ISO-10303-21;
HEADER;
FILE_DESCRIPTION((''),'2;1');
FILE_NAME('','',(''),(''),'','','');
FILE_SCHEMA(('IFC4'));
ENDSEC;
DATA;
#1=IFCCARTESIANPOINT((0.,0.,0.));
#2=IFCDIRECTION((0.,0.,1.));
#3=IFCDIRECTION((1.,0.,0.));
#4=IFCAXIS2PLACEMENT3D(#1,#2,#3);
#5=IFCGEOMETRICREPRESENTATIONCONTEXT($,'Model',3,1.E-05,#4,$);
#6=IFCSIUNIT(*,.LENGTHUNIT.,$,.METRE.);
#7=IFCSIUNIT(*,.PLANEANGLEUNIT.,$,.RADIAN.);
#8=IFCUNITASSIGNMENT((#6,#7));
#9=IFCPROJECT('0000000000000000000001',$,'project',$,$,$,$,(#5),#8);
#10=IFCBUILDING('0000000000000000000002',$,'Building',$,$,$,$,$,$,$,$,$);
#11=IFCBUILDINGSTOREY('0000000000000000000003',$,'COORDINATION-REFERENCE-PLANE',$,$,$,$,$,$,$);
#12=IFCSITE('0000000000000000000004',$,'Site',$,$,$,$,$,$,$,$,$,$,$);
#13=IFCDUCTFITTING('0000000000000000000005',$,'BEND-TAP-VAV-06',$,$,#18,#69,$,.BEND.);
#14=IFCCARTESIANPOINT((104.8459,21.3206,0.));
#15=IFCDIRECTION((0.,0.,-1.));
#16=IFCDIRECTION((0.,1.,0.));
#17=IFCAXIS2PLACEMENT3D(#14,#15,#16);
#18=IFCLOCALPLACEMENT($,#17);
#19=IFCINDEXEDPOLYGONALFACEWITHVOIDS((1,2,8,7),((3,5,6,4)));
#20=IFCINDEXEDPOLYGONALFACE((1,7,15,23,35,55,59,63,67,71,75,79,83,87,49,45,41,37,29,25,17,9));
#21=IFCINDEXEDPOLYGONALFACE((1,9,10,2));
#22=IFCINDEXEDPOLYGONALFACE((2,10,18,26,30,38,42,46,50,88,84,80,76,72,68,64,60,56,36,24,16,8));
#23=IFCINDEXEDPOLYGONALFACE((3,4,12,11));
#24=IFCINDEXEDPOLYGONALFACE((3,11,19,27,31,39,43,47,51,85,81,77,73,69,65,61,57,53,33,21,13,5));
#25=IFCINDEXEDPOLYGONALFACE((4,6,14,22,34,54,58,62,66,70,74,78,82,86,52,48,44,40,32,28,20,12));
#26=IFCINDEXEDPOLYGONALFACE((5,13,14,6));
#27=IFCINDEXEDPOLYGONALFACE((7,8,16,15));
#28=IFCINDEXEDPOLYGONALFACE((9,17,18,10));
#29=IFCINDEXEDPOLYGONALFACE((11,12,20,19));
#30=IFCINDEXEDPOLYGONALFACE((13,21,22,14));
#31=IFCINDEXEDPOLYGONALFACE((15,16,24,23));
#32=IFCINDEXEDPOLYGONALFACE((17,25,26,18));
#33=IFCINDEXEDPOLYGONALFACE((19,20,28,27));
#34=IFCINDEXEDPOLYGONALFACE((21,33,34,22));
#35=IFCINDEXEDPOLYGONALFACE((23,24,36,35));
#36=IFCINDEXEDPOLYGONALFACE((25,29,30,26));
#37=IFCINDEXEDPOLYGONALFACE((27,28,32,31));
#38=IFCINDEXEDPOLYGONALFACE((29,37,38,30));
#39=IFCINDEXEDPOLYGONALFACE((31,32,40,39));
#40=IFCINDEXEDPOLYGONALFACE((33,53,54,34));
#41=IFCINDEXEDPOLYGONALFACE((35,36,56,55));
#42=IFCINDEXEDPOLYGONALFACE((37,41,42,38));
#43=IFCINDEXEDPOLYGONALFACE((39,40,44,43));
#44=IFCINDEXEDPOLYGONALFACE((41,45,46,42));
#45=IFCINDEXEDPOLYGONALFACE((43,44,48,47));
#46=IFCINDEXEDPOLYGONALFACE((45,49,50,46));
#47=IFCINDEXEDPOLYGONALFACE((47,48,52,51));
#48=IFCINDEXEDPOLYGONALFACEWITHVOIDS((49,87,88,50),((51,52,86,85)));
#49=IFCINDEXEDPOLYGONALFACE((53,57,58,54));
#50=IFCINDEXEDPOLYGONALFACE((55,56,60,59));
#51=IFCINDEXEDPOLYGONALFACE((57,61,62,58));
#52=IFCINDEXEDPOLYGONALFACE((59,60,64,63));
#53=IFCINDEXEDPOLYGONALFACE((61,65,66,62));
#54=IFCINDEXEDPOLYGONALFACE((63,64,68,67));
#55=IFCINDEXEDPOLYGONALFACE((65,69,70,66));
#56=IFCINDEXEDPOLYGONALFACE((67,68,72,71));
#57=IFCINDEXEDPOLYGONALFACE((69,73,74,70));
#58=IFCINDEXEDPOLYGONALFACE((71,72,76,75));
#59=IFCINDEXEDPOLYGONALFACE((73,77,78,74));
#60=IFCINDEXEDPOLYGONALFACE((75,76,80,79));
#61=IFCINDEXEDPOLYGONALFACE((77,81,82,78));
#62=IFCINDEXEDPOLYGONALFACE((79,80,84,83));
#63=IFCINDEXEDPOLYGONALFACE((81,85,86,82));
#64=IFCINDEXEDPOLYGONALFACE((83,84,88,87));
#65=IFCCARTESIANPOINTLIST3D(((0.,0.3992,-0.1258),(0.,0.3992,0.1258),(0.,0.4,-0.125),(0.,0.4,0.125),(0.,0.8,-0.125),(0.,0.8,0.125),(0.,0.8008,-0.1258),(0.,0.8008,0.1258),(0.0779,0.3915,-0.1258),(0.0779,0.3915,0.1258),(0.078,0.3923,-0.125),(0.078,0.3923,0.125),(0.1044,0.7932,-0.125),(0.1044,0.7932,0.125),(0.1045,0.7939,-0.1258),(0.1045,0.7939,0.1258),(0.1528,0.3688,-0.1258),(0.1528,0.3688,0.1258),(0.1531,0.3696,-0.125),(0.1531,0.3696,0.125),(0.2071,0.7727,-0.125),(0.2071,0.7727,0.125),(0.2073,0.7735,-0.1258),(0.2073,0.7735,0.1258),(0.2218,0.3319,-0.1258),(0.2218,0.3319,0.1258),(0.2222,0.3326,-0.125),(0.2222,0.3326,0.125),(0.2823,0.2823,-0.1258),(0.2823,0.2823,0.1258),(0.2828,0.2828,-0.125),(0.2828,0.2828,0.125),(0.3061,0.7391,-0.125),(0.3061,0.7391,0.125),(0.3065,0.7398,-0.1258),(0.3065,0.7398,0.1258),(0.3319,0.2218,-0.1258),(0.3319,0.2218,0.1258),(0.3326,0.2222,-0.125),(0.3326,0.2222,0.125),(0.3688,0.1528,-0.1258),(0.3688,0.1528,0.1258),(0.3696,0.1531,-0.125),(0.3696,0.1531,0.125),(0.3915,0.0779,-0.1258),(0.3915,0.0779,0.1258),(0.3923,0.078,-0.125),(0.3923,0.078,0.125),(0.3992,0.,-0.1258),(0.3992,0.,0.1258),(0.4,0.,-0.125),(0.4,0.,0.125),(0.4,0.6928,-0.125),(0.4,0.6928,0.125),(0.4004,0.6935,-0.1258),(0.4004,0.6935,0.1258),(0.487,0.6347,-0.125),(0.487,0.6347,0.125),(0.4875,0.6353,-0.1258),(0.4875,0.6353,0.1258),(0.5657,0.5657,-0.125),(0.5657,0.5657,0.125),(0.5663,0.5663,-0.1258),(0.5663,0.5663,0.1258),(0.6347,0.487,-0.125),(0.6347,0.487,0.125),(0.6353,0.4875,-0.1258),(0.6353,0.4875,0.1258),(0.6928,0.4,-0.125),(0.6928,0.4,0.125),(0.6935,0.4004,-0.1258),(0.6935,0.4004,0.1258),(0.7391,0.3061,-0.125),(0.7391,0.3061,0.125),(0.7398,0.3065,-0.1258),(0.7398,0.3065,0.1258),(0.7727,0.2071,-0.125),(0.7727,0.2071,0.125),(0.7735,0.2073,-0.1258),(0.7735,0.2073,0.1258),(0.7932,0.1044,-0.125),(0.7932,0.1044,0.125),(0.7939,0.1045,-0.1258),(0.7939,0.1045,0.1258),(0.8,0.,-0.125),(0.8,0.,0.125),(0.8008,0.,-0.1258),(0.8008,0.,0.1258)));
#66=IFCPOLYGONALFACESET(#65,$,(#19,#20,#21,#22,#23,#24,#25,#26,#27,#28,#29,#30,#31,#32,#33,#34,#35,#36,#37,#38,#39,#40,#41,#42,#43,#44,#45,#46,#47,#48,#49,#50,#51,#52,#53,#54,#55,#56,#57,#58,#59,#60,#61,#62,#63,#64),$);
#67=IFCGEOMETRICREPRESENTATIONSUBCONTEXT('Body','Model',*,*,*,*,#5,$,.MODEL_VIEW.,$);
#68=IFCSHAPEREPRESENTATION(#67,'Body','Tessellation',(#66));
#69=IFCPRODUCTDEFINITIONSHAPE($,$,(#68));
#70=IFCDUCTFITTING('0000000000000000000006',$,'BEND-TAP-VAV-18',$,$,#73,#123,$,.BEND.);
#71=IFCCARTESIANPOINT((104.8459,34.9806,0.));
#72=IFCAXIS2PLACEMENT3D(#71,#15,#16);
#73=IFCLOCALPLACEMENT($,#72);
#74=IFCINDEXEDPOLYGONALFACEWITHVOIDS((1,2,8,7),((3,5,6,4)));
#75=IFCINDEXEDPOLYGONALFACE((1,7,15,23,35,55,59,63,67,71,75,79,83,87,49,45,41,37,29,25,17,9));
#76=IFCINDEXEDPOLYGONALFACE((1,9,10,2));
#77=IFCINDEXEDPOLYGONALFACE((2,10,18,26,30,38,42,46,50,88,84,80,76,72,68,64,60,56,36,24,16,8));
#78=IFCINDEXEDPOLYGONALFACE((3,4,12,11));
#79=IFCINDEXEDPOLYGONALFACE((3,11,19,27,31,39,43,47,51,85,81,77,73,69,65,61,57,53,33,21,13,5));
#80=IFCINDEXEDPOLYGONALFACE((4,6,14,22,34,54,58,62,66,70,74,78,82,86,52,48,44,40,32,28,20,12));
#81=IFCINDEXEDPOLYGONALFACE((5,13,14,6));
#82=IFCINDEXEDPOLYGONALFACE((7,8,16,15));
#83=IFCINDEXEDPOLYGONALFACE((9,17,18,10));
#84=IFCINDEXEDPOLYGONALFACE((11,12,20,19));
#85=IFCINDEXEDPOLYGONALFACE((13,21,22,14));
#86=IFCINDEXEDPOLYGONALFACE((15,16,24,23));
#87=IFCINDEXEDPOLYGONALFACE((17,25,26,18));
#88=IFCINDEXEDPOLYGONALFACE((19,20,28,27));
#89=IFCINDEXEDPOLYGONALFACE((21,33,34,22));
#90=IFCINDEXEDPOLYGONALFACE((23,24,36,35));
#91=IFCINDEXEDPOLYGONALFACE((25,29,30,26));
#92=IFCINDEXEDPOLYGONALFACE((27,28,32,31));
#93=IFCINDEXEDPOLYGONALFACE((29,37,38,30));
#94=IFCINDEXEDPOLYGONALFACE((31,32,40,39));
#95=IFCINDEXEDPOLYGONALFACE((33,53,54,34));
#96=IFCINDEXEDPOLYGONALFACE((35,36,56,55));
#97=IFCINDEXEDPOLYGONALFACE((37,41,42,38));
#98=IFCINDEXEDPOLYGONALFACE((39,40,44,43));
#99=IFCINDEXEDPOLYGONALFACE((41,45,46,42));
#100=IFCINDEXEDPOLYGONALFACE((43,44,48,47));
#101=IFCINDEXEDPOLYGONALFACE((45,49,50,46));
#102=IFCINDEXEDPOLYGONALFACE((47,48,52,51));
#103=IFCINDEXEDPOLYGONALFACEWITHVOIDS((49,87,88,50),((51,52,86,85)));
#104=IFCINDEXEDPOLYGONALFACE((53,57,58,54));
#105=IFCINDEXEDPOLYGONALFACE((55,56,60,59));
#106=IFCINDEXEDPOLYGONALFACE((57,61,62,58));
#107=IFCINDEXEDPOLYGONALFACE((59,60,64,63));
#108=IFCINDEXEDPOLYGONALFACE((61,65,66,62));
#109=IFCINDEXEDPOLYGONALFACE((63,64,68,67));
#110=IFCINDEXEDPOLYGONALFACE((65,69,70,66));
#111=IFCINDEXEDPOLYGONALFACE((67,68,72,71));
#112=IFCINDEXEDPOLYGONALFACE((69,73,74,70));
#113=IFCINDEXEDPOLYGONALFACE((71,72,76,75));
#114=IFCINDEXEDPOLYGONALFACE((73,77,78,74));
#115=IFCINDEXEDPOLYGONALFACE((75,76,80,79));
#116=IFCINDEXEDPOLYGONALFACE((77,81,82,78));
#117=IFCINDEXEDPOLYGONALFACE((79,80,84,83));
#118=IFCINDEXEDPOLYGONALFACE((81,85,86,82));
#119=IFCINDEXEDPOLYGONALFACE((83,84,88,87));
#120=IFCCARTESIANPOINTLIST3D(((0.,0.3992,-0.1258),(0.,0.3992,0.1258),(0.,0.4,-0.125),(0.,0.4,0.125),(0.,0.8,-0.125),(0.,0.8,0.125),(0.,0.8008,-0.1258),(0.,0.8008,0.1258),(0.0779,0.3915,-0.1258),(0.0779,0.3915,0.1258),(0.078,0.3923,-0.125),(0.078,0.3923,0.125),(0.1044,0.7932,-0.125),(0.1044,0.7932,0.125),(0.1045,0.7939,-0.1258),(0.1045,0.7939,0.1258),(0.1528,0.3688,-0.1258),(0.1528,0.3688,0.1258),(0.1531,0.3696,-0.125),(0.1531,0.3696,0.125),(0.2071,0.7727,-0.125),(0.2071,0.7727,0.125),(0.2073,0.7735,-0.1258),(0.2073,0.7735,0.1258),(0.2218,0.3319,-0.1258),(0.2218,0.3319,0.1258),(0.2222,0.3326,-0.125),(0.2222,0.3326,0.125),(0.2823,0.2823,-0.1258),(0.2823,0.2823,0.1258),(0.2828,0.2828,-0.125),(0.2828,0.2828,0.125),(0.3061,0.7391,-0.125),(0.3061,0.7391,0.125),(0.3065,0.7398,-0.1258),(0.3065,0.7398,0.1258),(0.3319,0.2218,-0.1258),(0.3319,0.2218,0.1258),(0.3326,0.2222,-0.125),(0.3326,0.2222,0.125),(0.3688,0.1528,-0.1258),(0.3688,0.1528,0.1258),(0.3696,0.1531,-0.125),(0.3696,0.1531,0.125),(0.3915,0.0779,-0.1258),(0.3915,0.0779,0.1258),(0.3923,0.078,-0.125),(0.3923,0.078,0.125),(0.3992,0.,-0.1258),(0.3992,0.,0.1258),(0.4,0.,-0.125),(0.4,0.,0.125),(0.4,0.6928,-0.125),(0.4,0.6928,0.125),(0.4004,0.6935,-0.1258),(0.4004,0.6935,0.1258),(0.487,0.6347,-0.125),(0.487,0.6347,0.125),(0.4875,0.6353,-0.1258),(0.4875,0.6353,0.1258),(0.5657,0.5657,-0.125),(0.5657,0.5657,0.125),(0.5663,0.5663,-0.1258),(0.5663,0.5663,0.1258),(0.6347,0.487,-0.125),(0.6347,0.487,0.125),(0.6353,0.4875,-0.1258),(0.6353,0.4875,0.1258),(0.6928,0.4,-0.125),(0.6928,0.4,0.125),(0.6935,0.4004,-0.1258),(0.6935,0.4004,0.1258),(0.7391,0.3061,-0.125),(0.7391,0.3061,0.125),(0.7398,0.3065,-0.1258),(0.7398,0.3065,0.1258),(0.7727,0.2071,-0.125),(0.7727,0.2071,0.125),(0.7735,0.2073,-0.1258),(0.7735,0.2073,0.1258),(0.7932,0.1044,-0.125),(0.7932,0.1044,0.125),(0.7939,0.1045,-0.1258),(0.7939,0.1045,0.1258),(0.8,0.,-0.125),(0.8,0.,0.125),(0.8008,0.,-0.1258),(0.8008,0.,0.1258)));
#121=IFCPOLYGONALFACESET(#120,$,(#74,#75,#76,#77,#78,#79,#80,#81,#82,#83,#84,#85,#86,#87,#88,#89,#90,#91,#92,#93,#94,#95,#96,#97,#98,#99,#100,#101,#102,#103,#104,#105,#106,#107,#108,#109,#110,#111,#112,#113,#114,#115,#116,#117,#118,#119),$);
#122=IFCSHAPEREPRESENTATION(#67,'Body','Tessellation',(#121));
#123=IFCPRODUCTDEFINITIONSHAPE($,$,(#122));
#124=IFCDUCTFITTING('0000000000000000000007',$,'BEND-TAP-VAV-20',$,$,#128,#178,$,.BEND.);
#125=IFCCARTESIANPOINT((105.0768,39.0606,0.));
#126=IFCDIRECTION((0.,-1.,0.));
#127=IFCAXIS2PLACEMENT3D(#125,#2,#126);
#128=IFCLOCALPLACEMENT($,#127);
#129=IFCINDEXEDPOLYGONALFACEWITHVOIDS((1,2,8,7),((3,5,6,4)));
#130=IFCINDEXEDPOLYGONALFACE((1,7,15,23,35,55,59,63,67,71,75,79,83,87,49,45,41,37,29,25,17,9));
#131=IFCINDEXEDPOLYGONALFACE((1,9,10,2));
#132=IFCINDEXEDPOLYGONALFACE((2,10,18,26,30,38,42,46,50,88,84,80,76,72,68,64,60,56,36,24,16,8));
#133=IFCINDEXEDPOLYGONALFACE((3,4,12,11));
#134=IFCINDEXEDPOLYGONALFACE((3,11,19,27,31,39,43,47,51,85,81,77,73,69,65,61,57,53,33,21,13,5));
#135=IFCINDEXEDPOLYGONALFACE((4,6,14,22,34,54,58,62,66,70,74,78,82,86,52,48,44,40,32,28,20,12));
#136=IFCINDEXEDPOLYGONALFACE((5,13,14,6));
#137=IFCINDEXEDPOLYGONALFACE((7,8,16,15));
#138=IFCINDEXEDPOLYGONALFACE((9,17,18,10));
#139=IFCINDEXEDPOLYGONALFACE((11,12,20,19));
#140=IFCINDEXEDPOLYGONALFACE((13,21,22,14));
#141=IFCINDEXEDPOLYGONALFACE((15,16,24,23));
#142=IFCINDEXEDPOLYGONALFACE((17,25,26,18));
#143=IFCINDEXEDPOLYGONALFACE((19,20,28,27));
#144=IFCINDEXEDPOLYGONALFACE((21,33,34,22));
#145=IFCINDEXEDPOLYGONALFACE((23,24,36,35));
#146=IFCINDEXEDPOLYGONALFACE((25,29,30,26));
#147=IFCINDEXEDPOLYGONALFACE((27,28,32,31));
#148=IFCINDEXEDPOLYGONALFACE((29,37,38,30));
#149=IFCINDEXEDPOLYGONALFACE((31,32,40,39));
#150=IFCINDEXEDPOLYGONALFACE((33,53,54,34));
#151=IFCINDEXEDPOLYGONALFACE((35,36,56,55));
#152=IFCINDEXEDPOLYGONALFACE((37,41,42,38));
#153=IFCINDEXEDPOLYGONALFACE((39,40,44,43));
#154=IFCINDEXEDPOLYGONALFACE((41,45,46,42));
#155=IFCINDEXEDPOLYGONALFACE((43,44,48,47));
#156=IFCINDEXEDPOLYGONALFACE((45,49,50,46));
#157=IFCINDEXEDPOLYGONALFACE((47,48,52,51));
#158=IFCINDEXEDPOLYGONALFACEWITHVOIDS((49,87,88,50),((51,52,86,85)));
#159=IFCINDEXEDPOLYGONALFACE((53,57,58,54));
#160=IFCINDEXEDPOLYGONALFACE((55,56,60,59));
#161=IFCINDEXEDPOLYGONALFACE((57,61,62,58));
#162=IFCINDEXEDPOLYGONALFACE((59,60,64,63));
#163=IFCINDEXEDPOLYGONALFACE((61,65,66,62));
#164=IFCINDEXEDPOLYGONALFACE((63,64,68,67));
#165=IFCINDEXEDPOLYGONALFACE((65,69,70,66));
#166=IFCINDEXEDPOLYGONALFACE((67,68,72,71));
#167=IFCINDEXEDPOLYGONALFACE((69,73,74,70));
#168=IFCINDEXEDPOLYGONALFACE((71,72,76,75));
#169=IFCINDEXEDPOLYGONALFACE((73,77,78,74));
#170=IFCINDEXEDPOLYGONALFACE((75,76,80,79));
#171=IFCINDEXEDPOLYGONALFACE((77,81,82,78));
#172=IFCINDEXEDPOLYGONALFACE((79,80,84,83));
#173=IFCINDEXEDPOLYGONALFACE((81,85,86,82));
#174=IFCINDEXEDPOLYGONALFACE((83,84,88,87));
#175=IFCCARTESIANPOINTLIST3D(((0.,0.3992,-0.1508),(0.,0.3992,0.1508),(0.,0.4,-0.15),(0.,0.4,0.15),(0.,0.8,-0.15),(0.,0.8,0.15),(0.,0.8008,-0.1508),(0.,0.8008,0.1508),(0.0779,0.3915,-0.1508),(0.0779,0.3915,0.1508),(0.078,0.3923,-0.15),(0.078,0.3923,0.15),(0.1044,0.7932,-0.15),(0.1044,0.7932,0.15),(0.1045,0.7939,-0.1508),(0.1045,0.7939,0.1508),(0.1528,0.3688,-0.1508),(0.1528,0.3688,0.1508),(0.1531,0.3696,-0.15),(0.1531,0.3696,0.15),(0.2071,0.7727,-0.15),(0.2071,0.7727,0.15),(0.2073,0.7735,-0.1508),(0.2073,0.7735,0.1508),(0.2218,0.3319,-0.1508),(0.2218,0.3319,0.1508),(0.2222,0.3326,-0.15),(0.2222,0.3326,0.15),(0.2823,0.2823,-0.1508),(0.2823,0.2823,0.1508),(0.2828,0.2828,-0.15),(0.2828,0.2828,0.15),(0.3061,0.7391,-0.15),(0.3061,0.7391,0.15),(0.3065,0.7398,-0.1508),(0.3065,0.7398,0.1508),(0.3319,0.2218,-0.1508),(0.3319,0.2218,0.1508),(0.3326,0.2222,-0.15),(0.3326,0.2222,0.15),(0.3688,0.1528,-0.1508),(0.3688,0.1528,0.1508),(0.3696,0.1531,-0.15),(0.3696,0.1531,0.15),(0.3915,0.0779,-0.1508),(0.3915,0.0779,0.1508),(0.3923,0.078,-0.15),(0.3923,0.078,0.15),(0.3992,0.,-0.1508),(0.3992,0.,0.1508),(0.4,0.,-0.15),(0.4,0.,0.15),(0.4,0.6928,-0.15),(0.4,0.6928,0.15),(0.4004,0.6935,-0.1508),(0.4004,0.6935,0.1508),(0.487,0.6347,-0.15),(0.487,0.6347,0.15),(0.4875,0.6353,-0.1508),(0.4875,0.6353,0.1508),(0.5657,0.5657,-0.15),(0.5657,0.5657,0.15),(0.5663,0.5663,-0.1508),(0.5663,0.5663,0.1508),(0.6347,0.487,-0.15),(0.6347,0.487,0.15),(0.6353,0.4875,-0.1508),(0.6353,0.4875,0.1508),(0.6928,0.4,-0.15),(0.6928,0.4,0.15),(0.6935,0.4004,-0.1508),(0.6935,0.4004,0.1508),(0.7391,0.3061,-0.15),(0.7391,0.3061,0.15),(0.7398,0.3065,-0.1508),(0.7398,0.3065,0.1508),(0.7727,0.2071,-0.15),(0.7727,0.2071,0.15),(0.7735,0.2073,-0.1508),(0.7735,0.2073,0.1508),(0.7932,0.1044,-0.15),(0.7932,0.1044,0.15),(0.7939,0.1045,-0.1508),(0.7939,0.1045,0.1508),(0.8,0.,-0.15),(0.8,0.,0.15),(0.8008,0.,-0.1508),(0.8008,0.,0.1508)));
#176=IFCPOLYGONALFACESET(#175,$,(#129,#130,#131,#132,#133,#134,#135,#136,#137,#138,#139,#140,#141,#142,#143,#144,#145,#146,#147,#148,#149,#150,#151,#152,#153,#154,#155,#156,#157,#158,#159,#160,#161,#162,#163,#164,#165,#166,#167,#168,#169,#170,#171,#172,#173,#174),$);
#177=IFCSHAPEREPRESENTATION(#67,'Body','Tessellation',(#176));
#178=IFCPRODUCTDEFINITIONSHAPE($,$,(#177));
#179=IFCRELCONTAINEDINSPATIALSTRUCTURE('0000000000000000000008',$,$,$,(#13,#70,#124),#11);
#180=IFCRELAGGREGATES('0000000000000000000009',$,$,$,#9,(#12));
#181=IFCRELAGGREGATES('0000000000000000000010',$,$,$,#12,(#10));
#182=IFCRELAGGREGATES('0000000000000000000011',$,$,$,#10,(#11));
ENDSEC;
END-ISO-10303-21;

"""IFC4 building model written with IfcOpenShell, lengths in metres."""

from ifc_helpers import new_model, entity, si_unit, frame, origin_with_axes, place, context, subcontext, project, spatial, element, save


model = new_model("IFC4")

# Units and contexts
model_context = context("Model", 3, precision=1e-05, world=origin_with_axes())
body_context = subcontext(model_context, "Body", "Model", "MODEL_VIEW")
ifc_project = project(units=[si_unit("LENGTHUNIT", "METRE"), si_unit("PLANEANGLEUNIT", "RADIAN")], contexts=[model_context])

# Site, building, storey
site = spatial("IfcSite", under=ifc_project, Name="Site")
building = spatial("IfcBuilding", under=site, Name="Building")
storey = spatial("IfcBuildingStorey", under=building, Name="COORDINATION-REFERENCE-PLANE")

# Duct fittings
duct_fitting_1_placement = place(None, frame((104.8459, 21.3206, 0.0), z_axis=(0.0, 0.0, -1.0), x_axis=(0.0, 1.0, 0.0)))
cartesian_point_1 = entity("IfcCartesianPoint", [0.0, 0.0, 0.0])
element("IfcDuctFitting", 1, at=duct_fitting_1_placement, inside=storey, Name="BEND-TAP-VAV-06", PredefinedType="BEND", context=body_context, shape_type="SweptSolid", body=[
    entity("IfcRevolvedAreaSolid", entity("IfcRectangleHollowProfileDef", "AREA", None, entity("IfcAxis2Placement2D", entity("IfcCartesianPoint", [0.6, 0.0])), 0.4016, 0.2516, 0.0008), entity("IfcAxis2Placement3D", cartesian_point_1, entity("IfcDirection", [0.0, -1.0, 0.0]), entity("IfcDirection", [1.0, 0.0, 0.0])), entity("IfcAxis1Placement", cartesian_point_1, entity("IfcDirection", [0.0, 1.0, 0.0])), 1.570796),
])
duct_fitting_2_placement = place(None, frame((104.8459, 34.9806, 0.0), z_axis=(0.0, 0.0, -1.0), x_axis=(0.0, 1.0, 0.0)))
cartesian_point_2 = entity("IfcCartesianPoint", [0.0, 0.0, 0.0])
element("IfcDuctFitting", 2, at=duct_fitting_2_placement, inside=storey, Name="BEND-TAP-VAV-18", PredefinedType="BEND", context=body_context, shape_type="SweptSolid", body=[
    entity("IfcRevolvedAreaSolid", entity("IfcRectangleHollowProfileDef", "AREA", None, entity("IfcAxis2Placement2D", entity("IfcCartesianPoint", [0.6, 0.0])), 0.4016, 0.2516, 0.0008), entity("IfcAxis2Placement3D", cartesian_point_2, entity("IfcDirection", [0.0, -1.0, 0.0]), entity("IfcDirection", [1.0, 0.0, 0.0])), entity("IfcAxis1Placement", cartesian_point_2, entity("IfcDirection", [0.0, 1.0, 0.0])), 1.570796),
])
duct_fitting_3_placement = place(None, frame((105.0768, 39.0606, 0.0), z_axis=(0.0, 0.0, 1.0), x_axis=(0.0, -1.0, 0.0)))
cartesian_point_3 = entity("IfcCartesianPoint", [0.0, 0.0, 0.0])
element("IfcDuctFitting", 3, at=duct_fitting_3_placement, inside=storey, Name="BEND-TAP-VAV-20", PredefinedType="BEND", context=body_context, shape_type="SweptSolid", body=[
    entity("IfcRevolvedAreaSolid", entity("IfcRectangleHollowProfileDef", "AREA", None, entity("IfcAxis2Placement2D", entity("IfcCartesianPoint", [0.6, 0.0])), 0.4016, 0.3016, 0.0008), entity("IfcAxis2Placement3D", cartesian_point_3, entity("IfcDirection", [0.0, -1.0, 0.0]), entity("IfcDirection", [1.0, 0.0, 0.0])), entity("IfcAxis1Placement", cartesian_point_3, entity("IfcDirection", [0.0, 1.0, 0.0])), 1.570796),
])

save(model, "model.ifc")
